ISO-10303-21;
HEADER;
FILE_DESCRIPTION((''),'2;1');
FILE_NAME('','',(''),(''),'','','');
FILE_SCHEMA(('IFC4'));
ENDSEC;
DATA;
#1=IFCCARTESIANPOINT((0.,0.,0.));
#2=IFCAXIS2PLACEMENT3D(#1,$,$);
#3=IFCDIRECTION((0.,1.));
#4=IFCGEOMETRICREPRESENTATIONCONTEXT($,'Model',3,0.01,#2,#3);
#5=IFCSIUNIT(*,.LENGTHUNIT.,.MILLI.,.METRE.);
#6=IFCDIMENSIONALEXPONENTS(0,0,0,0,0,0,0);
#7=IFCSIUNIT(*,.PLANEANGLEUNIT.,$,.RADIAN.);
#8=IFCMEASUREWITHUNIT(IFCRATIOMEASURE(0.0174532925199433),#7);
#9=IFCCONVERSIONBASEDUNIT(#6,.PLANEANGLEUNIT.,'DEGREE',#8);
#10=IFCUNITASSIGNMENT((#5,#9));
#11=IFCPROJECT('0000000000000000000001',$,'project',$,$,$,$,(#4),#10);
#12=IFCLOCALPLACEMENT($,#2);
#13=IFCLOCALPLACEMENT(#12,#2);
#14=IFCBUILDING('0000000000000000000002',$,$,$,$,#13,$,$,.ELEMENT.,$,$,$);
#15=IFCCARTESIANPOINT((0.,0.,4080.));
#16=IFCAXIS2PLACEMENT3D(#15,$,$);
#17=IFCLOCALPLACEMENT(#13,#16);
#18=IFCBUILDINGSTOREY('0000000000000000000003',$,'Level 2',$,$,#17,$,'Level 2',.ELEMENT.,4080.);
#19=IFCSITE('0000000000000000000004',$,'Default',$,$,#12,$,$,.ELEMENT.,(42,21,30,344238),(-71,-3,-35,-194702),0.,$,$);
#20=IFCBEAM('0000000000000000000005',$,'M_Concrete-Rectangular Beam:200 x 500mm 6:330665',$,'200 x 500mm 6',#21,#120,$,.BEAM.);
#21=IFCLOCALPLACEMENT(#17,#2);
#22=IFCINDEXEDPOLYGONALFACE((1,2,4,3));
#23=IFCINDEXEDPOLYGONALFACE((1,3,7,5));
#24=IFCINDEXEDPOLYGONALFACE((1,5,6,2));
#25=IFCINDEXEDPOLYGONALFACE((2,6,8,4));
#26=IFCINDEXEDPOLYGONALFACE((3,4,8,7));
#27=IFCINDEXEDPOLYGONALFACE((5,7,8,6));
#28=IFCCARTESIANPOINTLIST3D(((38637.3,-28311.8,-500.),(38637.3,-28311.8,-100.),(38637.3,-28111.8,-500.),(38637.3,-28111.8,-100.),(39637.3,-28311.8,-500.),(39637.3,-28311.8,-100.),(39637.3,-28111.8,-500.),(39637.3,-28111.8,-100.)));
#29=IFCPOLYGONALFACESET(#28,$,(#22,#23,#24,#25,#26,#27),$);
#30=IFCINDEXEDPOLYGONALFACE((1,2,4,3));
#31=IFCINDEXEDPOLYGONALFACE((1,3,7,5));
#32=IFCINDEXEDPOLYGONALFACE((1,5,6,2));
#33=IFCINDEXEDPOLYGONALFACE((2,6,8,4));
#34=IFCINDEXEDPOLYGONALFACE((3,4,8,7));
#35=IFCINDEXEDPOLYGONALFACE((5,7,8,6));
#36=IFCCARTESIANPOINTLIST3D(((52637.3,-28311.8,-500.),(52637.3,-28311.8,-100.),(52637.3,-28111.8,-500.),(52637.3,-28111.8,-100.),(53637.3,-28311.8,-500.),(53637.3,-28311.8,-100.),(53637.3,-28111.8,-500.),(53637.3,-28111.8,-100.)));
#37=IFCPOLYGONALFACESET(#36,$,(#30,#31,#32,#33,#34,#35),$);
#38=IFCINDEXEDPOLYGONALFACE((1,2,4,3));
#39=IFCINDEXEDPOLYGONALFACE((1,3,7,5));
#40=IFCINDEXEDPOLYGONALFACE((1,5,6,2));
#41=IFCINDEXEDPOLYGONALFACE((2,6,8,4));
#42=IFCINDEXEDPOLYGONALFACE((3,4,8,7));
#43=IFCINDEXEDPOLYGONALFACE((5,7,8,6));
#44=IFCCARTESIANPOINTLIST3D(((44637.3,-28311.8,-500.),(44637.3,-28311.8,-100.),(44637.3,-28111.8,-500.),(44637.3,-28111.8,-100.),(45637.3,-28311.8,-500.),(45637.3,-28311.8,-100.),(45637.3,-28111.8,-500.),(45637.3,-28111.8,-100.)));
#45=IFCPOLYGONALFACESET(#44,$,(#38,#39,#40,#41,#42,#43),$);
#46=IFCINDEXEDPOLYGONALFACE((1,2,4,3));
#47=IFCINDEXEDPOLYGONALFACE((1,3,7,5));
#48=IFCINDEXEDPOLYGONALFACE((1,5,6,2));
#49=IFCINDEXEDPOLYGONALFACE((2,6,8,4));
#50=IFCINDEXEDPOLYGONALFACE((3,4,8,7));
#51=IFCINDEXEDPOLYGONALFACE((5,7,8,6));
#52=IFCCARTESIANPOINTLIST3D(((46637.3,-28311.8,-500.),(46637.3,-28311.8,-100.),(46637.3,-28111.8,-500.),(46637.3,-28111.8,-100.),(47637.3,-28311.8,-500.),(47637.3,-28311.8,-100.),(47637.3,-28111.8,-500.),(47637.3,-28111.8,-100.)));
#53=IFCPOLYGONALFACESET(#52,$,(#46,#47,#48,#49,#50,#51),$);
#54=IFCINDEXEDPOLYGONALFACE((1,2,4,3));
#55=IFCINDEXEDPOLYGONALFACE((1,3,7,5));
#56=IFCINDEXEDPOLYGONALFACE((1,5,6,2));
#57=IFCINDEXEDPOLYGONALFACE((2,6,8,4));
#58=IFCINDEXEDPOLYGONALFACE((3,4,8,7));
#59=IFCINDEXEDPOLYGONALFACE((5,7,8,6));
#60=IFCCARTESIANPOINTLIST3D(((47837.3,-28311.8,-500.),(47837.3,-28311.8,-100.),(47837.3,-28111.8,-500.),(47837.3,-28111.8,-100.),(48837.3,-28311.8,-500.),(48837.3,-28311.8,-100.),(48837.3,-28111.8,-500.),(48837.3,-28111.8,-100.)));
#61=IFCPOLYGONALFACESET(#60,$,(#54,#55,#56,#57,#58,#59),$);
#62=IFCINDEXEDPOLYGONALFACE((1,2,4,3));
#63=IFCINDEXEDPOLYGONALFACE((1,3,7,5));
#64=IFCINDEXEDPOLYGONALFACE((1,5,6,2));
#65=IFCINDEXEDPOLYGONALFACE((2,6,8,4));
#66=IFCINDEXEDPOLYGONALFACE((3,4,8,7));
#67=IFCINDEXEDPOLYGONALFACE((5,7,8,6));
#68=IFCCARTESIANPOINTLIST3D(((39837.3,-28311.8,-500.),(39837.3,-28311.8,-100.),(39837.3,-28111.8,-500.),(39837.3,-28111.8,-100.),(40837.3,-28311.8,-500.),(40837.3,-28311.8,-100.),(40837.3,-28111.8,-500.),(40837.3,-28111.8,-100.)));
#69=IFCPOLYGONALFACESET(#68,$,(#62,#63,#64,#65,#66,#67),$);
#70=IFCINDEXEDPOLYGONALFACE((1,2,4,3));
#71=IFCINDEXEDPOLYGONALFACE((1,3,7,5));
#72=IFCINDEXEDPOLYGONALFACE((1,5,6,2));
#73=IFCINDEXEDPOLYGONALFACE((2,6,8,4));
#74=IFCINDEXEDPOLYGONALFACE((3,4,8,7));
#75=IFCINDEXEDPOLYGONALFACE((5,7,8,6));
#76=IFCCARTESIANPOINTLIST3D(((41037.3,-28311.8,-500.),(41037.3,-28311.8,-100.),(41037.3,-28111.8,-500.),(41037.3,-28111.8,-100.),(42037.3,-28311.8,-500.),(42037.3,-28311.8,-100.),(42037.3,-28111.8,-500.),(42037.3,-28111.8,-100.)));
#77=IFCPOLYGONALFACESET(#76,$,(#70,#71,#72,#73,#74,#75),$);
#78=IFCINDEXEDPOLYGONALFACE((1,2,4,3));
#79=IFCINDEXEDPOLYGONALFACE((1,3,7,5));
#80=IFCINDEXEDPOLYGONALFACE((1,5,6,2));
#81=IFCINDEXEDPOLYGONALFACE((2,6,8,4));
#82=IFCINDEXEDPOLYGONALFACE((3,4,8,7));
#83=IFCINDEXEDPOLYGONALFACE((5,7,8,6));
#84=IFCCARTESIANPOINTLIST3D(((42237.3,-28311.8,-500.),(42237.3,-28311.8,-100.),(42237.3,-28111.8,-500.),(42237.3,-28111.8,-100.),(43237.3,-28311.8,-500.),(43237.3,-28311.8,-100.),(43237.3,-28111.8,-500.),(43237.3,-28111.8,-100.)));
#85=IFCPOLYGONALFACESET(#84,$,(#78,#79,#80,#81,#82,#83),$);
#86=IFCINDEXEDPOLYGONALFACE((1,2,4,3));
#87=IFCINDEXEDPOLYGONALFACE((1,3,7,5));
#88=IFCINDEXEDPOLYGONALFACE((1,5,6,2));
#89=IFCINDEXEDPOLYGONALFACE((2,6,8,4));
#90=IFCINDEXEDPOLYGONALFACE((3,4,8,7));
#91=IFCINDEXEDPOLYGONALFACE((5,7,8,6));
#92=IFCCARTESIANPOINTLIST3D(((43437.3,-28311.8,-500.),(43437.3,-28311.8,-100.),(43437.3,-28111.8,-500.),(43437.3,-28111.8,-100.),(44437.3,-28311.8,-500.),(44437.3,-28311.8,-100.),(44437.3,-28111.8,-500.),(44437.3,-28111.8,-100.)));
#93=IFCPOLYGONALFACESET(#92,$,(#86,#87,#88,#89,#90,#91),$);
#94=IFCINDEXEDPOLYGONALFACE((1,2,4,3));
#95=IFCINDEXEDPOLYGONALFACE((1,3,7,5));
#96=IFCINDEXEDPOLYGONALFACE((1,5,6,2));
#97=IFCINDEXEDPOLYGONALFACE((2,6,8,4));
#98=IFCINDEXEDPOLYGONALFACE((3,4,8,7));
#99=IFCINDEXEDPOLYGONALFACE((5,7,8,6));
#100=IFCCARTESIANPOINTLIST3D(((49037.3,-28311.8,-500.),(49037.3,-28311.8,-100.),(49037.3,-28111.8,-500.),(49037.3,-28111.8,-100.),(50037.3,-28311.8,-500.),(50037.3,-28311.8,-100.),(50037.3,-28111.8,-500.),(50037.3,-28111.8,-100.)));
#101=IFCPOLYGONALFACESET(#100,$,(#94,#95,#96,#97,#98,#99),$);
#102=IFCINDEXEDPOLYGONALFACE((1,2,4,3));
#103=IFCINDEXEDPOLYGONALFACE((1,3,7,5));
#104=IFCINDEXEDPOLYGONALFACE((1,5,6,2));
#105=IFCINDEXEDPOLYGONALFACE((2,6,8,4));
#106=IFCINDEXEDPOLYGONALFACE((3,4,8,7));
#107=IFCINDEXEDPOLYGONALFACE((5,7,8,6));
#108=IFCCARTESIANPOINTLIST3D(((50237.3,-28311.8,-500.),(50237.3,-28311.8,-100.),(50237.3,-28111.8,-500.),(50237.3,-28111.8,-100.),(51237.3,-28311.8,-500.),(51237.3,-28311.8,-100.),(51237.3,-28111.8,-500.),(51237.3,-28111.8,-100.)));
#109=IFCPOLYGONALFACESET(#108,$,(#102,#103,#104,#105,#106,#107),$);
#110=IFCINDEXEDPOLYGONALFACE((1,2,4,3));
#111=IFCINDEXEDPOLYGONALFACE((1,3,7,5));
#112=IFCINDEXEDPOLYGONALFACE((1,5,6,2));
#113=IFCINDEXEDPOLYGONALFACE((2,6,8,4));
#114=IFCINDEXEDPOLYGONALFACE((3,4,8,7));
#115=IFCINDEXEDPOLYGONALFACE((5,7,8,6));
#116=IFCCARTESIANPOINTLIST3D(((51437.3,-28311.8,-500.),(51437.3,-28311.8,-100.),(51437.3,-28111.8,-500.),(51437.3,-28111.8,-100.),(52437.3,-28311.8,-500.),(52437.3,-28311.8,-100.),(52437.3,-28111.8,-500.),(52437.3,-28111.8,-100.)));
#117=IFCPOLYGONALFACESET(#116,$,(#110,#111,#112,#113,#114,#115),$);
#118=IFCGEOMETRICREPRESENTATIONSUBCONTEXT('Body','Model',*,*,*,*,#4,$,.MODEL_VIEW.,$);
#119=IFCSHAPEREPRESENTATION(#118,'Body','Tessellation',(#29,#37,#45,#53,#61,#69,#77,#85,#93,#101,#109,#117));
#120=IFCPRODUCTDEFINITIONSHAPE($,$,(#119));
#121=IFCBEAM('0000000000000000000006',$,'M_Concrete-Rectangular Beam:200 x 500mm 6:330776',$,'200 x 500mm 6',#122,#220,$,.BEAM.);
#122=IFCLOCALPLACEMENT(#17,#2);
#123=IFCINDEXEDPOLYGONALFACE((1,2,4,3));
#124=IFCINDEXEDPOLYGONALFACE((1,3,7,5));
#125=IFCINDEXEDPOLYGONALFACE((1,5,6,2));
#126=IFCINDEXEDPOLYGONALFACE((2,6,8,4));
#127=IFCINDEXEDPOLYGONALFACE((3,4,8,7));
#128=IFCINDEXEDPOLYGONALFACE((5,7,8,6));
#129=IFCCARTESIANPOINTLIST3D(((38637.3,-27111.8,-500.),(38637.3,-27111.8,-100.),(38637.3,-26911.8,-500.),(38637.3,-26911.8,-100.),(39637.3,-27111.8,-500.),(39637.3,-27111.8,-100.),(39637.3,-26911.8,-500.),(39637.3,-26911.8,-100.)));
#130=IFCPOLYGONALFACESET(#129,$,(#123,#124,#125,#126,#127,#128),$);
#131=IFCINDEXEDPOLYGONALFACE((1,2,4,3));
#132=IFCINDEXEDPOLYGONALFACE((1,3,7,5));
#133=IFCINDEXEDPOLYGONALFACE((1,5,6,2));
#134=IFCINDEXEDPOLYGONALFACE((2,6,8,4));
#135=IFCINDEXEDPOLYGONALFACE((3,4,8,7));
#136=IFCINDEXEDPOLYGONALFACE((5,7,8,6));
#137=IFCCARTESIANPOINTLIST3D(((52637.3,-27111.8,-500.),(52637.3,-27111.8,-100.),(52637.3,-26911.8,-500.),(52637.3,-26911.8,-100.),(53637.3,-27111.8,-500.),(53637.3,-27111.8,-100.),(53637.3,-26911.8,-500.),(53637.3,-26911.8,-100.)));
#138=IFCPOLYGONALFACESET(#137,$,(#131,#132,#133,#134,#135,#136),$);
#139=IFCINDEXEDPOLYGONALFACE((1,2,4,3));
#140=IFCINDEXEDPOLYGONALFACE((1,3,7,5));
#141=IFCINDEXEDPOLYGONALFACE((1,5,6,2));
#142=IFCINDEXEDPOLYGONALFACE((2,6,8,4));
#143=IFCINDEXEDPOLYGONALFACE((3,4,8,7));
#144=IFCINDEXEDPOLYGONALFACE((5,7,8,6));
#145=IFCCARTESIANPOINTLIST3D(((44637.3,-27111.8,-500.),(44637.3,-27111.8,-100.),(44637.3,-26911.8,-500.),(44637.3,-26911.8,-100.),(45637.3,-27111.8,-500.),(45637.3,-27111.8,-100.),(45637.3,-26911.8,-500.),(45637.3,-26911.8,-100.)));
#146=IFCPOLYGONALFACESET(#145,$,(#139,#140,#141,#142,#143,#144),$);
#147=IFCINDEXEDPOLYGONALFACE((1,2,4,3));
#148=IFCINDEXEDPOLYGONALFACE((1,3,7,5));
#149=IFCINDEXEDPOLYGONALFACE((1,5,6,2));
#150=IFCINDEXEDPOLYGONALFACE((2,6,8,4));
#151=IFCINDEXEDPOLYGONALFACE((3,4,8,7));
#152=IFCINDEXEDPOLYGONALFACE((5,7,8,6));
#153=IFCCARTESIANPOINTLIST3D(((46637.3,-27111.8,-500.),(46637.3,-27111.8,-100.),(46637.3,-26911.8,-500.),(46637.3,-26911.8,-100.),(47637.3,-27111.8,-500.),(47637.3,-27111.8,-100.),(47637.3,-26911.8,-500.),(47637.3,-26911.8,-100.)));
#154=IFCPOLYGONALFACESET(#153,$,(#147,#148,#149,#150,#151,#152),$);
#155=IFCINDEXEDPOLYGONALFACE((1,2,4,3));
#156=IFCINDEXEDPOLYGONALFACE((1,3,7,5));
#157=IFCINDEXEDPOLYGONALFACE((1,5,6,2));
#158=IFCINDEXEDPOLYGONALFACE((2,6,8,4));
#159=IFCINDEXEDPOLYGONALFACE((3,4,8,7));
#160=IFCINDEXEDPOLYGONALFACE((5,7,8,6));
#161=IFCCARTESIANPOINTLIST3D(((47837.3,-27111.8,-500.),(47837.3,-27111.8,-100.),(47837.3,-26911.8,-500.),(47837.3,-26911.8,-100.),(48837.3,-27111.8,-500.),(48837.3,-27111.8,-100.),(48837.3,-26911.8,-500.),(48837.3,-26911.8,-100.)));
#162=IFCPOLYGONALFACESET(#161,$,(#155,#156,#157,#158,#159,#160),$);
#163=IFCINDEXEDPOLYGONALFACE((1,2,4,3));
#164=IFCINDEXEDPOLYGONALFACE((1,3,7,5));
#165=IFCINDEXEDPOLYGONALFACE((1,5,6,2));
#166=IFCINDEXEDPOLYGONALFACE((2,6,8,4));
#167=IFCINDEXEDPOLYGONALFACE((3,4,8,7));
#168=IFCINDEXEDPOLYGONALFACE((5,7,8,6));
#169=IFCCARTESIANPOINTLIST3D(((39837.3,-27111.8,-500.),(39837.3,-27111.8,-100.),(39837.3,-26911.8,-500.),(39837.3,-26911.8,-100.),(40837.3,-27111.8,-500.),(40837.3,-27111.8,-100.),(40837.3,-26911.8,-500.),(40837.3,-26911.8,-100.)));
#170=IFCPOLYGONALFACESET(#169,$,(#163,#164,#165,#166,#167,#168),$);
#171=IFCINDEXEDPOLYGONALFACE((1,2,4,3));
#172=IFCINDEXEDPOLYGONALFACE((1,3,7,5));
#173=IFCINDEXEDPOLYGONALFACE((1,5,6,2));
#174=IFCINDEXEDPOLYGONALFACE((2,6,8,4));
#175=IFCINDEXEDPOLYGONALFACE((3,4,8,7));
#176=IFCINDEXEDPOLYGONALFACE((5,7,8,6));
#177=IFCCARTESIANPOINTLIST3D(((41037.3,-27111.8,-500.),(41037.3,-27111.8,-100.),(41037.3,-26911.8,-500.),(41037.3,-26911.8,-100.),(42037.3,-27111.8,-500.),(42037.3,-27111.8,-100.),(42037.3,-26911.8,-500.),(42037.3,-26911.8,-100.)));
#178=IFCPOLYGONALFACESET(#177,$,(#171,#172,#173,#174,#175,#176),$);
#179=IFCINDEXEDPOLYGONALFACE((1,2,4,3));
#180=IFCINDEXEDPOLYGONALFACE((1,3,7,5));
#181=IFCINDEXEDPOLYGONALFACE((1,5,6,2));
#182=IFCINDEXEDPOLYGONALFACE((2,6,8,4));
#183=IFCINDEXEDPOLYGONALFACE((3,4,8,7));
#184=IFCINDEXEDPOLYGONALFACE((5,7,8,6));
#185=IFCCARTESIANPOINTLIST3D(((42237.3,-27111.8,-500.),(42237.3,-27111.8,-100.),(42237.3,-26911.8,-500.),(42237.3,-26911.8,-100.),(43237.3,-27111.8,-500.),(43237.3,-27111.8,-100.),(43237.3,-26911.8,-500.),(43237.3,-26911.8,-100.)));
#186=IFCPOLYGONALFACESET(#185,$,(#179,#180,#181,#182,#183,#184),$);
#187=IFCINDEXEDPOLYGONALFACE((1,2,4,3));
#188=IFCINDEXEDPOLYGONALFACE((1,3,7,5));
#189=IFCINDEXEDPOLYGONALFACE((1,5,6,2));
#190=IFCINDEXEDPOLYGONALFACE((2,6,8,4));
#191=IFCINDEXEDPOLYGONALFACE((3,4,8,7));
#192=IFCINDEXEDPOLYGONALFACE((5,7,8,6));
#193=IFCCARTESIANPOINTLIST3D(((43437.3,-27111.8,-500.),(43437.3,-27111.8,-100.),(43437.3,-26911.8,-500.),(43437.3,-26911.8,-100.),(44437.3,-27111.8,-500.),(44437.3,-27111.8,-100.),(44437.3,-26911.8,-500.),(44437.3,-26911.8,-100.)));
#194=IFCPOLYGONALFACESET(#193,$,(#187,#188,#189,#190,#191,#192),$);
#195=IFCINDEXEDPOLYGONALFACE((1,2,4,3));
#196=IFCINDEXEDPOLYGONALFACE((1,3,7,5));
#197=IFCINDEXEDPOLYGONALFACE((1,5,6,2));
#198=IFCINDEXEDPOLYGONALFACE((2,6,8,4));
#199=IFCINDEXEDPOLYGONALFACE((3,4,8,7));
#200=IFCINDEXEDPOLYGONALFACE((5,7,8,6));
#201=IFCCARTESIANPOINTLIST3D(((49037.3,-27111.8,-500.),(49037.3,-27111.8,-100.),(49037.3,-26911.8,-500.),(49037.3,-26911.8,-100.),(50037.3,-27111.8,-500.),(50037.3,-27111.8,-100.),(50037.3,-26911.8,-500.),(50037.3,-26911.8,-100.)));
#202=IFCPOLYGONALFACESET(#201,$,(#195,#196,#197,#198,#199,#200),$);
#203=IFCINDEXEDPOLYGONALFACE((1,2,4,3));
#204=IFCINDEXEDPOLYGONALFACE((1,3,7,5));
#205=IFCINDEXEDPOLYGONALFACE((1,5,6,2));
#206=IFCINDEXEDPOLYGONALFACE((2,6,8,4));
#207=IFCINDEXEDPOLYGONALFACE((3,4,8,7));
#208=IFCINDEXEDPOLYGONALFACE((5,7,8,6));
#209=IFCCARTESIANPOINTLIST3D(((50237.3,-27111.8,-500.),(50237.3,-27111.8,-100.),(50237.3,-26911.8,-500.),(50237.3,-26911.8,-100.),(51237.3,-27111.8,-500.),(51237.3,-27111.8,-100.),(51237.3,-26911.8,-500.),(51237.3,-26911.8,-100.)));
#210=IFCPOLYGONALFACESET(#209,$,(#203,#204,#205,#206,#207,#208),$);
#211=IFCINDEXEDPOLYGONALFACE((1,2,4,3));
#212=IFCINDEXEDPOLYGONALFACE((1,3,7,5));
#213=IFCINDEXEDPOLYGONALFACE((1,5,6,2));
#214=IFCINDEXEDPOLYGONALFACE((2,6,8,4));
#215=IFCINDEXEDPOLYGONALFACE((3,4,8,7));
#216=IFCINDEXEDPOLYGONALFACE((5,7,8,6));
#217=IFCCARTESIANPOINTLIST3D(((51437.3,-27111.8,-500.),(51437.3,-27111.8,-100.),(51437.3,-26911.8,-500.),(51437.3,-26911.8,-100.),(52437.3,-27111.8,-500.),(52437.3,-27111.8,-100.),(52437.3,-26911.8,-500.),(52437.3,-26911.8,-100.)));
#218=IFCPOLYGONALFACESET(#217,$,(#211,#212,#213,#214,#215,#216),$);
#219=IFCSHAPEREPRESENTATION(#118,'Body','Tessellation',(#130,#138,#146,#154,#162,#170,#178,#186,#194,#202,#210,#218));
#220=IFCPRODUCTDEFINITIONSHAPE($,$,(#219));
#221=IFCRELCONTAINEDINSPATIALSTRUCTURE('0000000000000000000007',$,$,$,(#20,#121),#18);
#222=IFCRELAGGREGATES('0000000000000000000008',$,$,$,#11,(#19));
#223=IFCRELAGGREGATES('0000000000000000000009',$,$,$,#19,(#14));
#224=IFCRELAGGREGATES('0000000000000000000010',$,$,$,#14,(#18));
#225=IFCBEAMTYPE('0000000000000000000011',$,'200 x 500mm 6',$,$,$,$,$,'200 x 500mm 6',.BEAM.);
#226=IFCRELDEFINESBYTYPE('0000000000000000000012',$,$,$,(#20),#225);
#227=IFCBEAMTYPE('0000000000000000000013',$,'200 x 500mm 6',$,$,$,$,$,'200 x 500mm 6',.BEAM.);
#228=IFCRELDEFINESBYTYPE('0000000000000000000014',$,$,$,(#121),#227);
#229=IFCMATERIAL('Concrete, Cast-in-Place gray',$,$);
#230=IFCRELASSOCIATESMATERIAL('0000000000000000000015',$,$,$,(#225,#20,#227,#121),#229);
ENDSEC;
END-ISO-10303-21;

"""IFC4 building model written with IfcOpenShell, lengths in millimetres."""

from ifc_helpers import new_model, entity, si_unit, converted_unit, direction, frame, frame_2d, origin, origin_2d_with_axis, place, context, subcontext, project, spatial, rectangle, extrude, source, transform, mapped, material, type_object, type_shapes, element, save


model = new_model("IFC4")

# Units and contexts
model_context = context("Model", 3, precision=0.01, world=origin(), true_north=direction((0.0, 1.0)))
body_context = subcontext(model_context, "Body", "Model", "MODEL_VIEW")
ifc_project = project(units=[si_unit("LENGTHUNIT", "METRE", prefix="MILLI"), converted_unit("PLANEANGLEUNIT", "DEGREE", entity("IfcRatioMeasure", 0.0174532925199433), si_unit("PLANEANGLEUNIT", "RADIAN"), dimensions=[0, 0, 0, 0, 0, 0, 0])], contexts=[model_context])

# Site, building, storey
site_placement = place(None, origin())
site = spatial("IfcSite", under=ifc_project, at=site_placement, Name="Default", CompositionType="ELEMENT", RefLatitude=(42, 21, 30, 344238), RefLongitude=(-71, -3, -35, -194702), RefElevation=0.0)
building_placement = place(site_placement, origin())
building = spatial("IfcBuilding", under=site, at=building_placement, CompositionType="ELEMENT")
storey_placement = place(building_placement, frame((0.0, 0.0, 4080.0)))
storey = spatial("IfcBuildingStorey", under=building, at=storey_placement, Name="Level 2", LongName="Level 2", CompositionType="ELEMENT", Elevation=4080.0)

# Beams
ifc_material_1 = material(Name="Concrete, Cast-in-Place gray")
beam_type_1 = type_object("IfcBeamType", Name="200 x 500mm 6", ElementType="200 x 500mm 6", PredefinedType="BEAM", material=ifc_material_1)
shared_shape_1 = source(origin(), body_context, "Body", "SweptSolid", [
    extrude(rectangle(XDim=1000.0, YDim=200.0, at=origin_2d_with_axis()), frame((39137.3, -28211.8, 3580.0)), (0.0, 0.0, 1.0), 400.0),
    extrude(rectangle(XDim=1000.0, YDim=200.0, at=frame_2d((0.0, 0.0), x_axis=(1.0, 0.0))), frame((53137.3, -28211.8, 3580.0), z_axis=(0.0, 0.0, 1.0), x_axis=(-1.0, 0.0, 0.0)), (0.0, 0.0, 1.0), 400.0),
    extrude(rectangle(XDim=1000.0, YDim=200.0, at=frame_2d((0.0, 0.0), x_axis=(1.0, 0.0))), frame((45137.3, -28211.8, 3580.0), z_axis=(0.0, 0.0, 1.0), x_axis=(-1.0, 0.0, 0.0)), (0.0, 0.0, 1.0), 400.0),
    extrude(rectangle(XDim=1000.0, YDim=200.0, at=frame_2d((-133.3, 0.0), x_axis=(1.0, 0.0))), frame((47270.6, -28211.8, 3580.0)), (0.0, 0.0, 1.0), 400.0),
    extrude(rectangle(XDim=1000.0, YDim=200.0, at=frame_2d((0.0, 0.0), x_axis=(1.0, 0.0))), frame((48337.3, -28211.8, 3580.0)), (0.0, 0.0, 1.0), 400.0),
    extrude(rectangle(XDim=1000.0, YDim=200.0, at=frame_2d((0.0, 0.0), x_axis=(1.0, 0.0))), frame((40337.3, -28211.8, 3580.0)), (0.0, 0.0, 1.0), 400.0),
    extrude(rectangle(XDim=1000.0, YDim=200.0, at=frame_2d((0.0, 0.0), x_axis=(1.0, 0.0))), frame((41537.3, -28211.8, 3580.0)), (0.0, 0.0, 1.0), 400.0),
    extrude(rectangle(XDim=1000.0, YDim=200.0, at=frame_2d((0.0, 0.0), x_axis=(1.0, 0.0))), frame((42737.3, -28211.8, 3580.0)), (0.0, 0.0, 1.0), 400.0),
    extrude(rectangle(XDim=1000.0, YDim=200.0, at=frame_2d((0.0, 0.0), x_axis=(1.0, 0.0))), frame((43937.3, -28211.8, 3580.0)), (0.0, 0.0, 1.0), 400.0),
    extrude(rectangle(XDim=1000.0, YDim=200.0, at=frame_2d((0.0, 0.0), x_axis=(1.0, 0.0))), frame((49537.3, -28211.8, 3580.0)), (0.0, 0.0, 1.0), 400.0),
    extrude(rectangle(XDim=1000.0, YDim=200.0, at=frame_2d((0.0, 0.0), x_axis=(1.0, 0.0))), frame((50737.3, -28211.8, 3580.0)), (0.0, 0.0, 1.0), 400.0),
    extrude(rectangle(XDim=1000.0, YDim=200.0, at=frame_2d((0.0, 0.0), x_axis=(1.0, 0.0))), frame((51937.3, -28211.8, 3580.0)), (0.0, 0.0, 1.0), 400.0),
])
type_shapes(beam_type_1, [shared_shape_1])
beam_1_placement = place(storey_placement, frame((0.0, 0.0, -4080.0)))
element("IfcBeam", 1, at=beam_1_placement, inside=storey, type_object=beam_type_1, material=ifc_material_1, Name="M_Concrete-Rectangular Beam:200 x 500mm 6:330665", ObjectType="200 x 500mm 6", PredefinedType="BEAM", context=body_context, shape_type="MappedRepresentation", body=[
    mapped(shared_shape_1, transform((0.0, 0.0, 0.0), scale=1.0)),
])
beam_type_2 = type_object("IfcBeamType", Name="200 x 500mm 6", ElementType="200 x 500mm 6", PredefinedType="BEAM", material=ifc_material_1)
shared_shape_2 = source(origin(), body_context, "Body", "SweptSolid", [
    extrude(rectangle(XDim=1000.0, YDim=200.0, at=frame_2d((0.0, 0.0), x_axis=(1.0, 0.0))), frame((39137.3, -27011.8, 3580.0)), (0.0, 0.0, 1.0), 400.0),
    extrude(rectangle(XDim=1000.0, YDim=200.0, at=frame_2d((0.0, 0.0), x_axis=(1.0, 0.0))), frame((53137.3, -27011.8, 3580.0), z_axis=(0.0, 0.0, 1.0), x_axis=(-1.0, 0.0, 0.0)), (0.0, 0.0, 1.0), 400.0),
    extrude(rectangle(XDim=1000.0, YDim=200.0, at=frame_2d((0.0, 0.0), x_axis=(1.0, 0.0))), frame((45137.3, -27011.8, 3580.0), z_axis=(0.0, 0.0, 1.0), x_axis=(-1.0, 0.0, 0.0)), (0.0, 0.0, 1.0), 400.0),
    extrude(rectangle(XDim=1000.0, YDim=200.0, at=frame_2d((-133.3, 0.0), x_axis=(1.0, 0.0))), frame((47270.6, -27011.8, 3580.0)), (0.0, 0.0, 1.0), 400.0),
    extrude(rectangle(XDim=1000.0, YDim=200.0, at=frame_2d((0.0, 0.0), x_axis=(1.0, 0.0))), frame((48337.3, -27011.8, 3580.0)), (0.0, 0.0, 1.0), 400.0),
    extrude(rectangle(XDim=1000.0, YDim=200.0, at=frame_2d((0.0, 0.0), x_axis=(1.0, 0.0))), frame((40337.3, -27011.8, 3580.0)), (0.0, 0.0, 1.0), 400.0),
    extrude(rectangle(XDim=1000.0, YDim=200.0, at=frame_2d((0.0, 0.0), x_axis=(1.0, 0.0))), frame((41537.3, -27011.8, 3580.0)), (0.0, 0.0, 1.0), 400.0),
    extrude(rectangle(XDim=1000.0, YDim=200.0, at=frame_2d((0.0, 0.0), x_axis=(1.0, 0.0))), frame((42737.3, -27011.8, 3580.0)), (0.0, 0.0, 1.0), 400.0),
    extrude(rectangle(XDim=1000.0, YDim=200.0, at=frame_2d((0.0, 0.0), x_axis=(1.0, 0.0))), frame((43937.3, -27011.8, 3580.0)), (0.0, 0.0, 1.0), 400.0),
    extrude(rectangle(XDim=1000.0, YDim=200.0, at=frame_2d((0.0, 0.0), x_axis=(1.0, 0.0))), frame((49537.3, -27011.8, 3580.0)), (0.0, 0.0, 1.0), 400.0),
    extrude(rectangle(XDim=1000.0, YDim=200.0, at=frame_2d((0.0, 0.0), x_axis=(1.0, 0.0))), frame((50737.3, -27011.8, 3580.0)), (0.0, 0.0, 1.0), 400.0),
    extrude(rectangle(XDim=1000.0, YDim=200.0, at=frame_2d((0.0, 0.0), x_axis=(1.0, 0.0))), frame((51937.3, -27011.8, 3580.0)), (0.0, 0.0, 1.0), 400.0),
])
type_shapes(beam_type_2, [shared_shape_2])
beam_2_placement = place(storey_placement, frame((0.0, 0.0, -4080.0)))
element("IfcBeam", 2, at=beam_2_placement, inside=storey, type_object=beam_type_2, material=ifc_material_1, Name="M_Concrete-Rectangular Beam:200 x 500mm 6:330776", ObjectType="200 x 500mm 6", PredefinedType="BEAM", context=body_context, shape_type="MappedRepresentation", body=[
    mapped(shared_shape_2, transform((0.0, 0.0, 0.0), scale=1.0)),
])

save(model, "model.ifc")
